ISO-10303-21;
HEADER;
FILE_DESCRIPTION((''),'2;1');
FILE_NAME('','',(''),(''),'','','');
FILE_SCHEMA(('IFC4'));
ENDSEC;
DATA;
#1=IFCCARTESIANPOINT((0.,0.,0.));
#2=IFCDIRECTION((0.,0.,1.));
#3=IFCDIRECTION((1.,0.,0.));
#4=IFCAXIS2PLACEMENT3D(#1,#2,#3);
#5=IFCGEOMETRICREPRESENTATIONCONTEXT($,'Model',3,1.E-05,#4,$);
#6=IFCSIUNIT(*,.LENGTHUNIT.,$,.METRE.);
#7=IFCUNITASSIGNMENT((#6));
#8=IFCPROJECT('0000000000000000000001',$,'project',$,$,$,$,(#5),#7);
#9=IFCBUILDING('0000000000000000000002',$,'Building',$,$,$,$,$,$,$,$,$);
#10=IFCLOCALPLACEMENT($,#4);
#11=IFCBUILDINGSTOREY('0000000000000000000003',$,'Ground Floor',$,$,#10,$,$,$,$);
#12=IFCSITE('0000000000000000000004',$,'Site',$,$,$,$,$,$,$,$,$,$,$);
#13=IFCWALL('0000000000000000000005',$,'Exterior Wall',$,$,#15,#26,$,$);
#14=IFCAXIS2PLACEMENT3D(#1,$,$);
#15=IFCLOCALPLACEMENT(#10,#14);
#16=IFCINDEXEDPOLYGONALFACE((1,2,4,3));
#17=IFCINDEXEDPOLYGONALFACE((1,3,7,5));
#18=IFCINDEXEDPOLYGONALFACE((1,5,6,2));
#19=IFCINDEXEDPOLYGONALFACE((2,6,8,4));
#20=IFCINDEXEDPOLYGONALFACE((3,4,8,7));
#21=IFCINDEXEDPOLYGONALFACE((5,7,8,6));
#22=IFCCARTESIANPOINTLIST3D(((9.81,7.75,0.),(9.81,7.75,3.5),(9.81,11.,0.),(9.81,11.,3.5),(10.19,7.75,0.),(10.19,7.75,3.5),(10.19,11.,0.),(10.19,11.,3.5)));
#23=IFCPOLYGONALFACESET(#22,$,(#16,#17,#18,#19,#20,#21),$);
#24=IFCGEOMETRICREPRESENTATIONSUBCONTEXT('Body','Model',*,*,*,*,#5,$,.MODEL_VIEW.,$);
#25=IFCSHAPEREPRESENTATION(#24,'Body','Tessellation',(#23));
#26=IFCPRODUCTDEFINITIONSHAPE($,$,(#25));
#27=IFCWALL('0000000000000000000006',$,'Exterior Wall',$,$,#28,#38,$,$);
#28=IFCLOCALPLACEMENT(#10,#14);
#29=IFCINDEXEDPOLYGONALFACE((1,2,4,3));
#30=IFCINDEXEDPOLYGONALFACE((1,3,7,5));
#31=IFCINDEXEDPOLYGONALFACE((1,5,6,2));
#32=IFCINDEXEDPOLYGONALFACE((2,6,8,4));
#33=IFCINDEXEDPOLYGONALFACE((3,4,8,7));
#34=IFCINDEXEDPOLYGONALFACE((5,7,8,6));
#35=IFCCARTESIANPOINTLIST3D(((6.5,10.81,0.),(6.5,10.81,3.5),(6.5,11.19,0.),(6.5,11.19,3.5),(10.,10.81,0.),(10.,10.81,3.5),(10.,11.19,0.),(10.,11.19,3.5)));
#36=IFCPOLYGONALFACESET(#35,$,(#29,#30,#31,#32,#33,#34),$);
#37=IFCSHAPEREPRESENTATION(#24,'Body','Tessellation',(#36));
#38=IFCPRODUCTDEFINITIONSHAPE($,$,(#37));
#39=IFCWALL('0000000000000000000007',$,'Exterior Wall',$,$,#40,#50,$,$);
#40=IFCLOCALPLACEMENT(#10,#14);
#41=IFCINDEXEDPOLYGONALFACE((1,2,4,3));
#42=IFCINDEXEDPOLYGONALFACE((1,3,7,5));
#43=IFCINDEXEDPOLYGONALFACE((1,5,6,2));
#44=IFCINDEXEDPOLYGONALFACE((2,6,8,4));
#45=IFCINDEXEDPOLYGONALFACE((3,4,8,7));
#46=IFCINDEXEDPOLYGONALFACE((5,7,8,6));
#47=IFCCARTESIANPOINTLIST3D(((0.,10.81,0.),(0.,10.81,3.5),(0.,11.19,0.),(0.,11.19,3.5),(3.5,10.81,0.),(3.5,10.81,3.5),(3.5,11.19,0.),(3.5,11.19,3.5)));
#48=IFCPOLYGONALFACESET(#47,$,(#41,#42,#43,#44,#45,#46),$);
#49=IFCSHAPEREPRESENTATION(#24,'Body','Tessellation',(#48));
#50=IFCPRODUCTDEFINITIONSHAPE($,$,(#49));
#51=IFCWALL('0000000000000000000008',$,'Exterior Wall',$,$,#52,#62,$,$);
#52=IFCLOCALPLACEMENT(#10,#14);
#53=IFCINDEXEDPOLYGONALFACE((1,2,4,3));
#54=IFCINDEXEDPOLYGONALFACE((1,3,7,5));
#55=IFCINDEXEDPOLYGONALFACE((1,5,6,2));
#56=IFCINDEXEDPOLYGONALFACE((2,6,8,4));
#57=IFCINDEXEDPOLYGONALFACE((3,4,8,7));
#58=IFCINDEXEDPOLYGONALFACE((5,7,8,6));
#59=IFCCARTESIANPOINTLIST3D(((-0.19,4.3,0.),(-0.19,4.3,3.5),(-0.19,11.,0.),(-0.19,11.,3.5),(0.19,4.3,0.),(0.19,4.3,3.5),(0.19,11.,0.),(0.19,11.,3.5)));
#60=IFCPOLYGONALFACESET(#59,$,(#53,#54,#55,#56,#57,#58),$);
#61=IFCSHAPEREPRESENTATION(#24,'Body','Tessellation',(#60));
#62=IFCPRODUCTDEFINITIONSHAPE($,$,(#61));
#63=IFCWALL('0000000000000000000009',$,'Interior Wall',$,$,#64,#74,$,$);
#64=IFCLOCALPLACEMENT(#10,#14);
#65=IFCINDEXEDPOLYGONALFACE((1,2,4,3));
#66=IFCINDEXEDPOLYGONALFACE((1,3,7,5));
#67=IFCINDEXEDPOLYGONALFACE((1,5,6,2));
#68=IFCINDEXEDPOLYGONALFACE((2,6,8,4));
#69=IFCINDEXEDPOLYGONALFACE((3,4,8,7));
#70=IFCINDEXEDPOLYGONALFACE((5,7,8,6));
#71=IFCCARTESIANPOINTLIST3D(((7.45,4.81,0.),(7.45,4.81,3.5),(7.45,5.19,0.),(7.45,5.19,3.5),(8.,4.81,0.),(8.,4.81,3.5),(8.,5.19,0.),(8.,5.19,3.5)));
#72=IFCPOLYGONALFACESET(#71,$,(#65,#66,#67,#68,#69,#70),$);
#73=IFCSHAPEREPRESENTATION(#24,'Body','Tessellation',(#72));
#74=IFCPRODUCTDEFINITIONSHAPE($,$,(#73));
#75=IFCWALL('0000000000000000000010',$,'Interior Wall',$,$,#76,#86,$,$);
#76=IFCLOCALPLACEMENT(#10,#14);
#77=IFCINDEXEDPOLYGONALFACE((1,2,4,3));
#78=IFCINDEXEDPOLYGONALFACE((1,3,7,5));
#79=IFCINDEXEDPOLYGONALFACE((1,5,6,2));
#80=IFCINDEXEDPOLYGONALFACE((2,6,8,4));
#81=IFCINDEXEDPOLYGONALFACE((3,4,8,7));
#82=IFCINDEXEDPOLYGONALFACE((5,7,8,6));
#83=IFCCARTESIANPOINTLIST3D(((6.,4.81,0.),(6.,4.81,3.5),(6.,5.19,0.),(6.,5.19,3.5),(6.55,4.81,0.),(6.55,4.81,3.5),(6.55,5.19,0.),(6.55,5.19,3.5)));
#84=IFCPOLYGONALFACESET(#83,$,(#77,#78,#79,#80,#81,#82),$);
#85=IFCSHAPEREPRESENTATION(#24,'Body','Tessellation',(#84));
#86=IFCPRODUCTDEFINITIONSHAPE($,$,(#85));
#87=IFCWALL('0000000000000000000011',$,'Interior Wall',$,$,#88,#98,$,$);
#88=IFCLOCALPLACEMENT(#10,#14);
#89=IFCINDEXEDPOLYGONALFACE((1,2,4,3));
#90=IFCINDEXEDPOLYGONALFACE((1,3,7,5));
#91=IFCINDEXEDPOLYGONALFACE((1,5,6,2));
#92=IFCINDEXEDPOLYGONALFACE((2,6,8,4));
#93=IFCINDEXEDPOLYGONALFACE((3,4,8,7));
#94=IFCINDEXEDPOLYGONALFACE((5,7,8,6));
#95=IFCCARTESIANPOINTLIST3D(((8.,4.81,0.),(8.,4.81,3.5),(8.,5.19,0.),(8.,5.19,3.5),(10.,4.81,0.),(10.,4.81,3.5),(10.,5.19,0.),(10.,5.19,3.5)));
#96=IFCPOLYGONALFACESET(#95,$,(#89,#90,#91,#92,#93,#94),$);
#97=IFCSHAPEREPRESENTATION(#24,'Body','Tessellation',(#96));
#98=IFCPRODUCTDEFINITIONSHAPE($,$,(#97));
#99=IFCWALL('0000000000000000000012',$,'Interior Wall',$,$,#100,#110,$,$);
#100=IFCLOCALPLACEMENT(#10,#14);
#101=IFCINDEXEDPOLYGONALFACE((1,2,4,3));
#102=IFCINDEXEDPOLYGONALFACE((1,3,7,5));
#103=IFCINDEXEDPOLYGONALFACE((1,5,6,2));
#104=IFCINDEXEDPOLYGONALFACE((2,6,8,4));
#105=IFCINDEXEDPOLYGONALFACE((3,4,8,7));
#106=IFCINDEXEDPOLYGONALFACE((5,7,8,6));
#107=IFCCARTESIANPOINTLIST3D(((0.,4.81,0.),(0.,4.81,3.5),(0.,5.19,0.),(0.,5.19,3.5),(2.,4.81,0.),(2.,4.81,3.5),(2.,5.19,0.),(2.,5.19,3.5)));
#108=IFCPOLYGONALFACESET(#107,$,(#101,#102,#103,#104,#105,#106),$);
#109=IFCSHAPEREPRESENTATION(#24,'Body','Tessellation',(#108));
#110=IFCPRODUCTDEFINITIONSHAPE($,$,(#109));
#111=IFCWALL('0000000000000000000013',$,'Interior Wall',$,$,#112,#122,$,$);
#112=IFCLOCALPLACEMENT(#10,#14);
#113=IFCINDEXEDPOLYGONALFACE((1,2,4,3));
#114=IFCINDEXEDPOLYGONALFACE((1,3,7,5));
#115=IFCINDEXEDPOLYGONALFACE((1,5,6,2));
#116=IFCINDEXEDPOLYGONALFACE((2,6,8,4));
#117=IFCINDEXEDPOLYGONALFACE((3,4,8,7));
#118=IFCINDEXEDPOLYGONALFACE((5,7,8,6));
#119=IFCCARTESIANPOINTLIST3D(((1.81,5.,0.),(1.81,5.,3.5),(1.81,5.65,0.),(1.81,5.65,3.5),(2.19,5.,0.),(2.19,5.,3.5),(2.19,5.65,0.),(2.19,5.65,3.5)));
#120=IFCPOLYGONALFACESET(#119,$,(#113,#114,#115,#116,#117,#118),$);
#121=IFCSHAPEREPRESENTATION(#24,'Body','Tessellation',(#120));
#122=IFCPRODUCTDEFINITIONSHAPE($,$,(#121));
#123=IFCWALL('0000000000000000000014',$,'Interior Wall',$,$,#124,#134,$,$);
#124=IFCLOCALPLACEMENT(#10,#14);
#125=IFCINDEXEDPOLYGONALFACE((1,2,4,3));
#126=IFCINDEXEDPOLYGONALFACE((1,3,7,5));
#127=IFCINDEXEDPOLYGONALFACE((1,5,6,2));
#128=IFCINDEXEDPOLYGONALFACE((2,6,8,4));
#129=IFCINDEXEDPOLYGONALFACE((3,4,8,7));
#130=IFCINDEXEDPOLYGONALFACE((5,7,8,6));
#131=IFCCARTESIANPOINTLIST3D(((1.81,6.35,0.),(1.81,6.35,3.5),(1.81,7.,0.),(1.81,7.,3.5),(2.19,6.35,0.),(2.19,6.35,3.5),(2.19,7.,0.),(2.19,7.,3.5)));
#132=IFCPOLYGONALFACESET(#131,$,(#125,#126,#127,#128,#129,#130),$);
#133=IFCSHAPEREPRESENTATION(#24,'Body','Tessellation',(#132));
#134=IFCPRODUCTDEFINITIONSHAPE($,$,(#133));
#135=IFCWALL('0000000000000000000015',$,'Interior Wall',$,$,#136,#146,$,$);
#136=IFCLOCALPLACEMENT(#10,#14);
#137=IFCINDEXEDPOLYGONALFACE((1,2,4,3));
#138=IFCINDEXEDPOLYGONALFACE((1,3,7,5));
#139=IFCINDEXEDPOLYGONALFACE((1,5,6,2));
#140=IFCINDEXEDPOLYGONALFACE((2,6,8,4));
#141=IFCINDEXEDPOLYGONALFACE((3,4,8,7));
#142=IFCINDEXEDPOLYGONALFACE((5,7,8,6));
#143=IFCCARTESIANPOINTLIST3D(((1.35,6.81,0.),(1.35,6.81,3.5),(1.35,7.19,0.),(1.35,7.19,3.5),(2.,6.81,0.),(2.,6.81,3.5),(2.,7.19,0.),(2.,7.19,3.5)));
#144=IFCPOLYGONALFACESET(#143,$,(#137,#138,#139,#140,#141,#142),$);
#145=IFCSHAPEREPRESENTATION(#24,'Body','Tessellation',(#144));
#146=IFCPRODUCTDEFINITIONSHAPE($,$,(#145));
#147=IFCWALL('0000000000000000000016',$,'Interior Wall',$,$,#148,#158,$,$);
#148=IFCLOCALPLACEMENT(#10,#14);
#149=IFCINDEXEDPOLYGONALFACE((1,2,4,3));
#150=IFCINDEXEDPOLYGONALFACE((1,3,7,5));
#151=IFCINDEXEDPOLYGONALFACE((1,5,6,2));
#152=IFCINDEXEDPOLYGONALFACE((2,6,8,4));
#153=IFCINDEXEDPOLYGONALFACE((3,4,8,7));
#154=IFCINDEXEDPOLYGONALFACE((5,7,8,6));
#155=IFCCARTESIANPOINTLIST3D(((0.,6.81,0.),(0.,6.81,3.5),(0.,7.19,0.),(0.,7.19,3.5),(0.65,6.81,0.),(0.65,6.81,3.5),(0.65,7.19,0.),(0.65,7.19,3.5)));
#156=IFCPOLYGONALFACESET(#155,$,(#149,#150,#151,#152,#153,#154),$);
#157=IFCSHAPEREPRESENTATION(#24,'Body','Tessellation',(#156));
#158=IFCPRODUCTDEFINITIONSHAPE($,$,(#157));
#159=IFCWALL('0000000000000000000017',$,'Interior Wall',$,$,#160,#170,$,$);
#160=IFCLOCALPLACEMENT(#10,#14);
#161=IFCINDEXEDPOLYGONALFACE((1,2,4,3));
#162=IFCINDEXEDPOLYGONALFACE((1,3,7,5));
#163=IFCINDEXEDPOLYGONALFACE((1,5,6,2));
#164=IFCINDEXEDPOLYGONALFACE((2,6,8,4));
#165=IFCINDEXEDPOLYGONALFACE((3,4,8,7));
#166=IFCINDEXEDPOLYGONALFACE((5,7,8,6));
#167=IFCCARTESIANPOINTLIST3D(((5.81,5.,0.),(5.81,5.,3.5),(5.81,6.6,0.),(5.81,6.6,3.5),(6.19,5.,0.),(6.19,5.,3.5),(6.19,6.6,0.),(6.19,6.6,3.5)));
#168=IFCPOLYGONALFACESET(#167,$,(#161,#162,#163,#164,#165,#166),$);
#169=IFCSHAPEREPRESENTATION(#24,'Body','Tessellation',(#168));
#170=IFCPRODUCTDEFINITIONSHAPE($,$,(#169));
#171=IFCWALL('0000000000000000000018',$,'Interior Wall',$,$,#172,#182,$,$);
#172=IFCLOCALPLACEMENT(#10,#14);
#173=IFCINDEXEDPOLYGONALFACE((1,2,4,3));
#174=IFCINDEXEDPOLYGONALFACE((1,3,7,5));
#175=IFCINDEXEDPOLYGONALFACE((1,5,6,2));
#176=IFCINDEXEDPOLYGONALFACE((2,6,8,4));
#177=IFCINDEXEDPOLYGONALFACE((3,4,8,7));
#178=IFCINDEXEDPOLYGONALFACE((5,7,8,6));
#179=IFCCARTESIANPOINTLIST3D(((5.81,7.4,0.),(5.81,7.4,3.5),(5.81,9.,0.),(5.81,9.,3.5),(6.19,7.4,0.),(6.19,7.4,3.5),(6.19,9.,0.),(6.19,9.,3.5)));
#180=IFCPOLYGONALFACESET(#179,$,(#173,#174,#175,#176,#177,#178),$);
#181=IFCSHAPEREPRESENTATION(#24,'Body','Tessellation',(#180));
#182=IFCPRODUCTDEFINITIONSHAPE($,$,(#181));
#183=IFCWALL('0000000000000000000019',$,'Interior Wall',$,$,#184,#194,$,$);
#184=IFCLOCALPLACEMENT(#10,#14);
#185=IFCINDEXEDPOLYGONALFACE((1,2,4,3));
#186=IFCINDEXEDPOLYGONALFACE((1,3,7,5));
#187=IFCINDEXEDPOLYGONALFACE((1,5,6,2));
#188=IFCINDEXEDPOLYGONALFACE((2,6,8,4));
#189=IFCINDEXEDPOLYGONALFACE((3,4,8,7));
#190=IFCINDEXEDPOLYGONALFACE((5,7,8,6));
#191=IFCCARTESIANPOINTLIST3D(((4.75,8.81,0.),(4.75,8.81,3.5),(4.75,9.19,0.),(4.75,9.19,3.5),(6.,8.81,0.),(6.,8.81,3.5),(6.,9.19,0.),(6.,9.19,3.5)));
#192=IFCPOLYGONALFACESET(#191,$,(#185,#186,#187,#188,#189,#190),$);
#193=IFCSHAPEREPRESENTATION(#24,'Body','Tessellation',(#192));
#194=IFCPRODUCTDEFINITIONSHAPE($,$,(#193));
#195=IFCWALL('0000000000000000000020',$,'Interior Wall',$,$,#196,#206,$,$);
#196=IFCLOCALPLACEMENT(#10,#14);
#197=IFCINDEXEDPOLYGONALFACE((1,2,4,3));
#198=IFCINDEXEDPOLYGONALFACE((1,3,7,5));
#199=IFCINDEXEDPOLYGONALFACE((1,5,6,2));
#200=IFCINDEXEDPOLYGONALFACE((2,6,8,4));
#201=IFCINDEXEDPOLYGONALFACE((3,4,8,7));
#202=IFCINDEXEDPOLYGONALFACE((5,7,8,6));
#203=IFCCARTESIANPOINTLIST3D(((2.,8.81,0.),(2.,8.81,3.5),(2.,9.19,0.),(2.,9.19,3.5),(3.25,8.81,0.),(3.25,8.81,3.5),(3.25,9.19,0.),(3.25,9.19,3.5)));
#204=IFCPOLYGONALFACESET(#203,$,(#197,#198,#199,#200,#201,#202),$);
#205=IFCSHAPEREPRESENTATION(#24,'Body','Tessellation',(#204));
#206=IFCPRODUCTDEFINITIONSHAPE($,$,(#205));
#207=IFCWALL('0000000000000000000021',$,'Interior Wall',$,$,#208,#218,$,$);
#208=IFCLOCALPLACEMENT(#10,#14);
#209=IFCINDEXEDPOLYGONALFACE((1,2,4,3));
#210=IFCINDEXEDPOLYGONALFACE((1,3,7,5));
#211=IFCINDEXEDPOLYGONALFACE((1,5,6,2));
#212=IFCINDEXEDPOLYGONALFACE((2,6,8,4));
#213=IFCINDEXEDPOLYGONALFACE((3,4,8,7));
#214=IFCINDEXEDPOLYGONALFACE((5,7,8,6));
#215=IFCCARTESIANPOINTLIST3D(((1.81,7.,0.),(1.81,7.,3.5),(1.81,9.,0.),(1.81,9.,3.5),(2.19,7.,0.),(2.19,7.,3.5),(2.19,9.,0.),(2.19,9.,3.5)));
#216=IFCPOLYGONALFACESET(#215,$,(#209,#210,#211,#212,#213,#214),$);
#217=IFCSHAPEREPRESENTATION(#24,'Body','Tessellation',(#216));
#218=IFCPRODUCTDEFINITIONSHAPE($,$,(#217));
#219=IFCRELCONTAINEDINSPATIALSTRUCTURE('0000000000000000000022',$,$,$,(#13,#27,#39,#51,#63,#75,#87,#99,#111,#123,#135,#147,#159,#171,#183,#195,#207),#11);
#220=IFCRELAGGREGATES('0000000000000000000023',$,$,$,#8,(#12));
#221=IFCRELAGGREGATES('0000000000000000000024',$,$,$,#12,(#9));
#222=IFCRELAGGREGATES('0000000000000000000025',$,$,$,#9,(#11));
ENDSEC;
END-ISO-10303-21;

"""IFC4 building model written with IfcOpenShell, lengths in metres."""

from ifc_helpers import new_model, si_unit, frame, origin_with_axes, place, context, subcontext, project, spatial, indexed_curve, outline, extrude, element, save


model = new_model("IFC4")

# Units and contexts
model_context = context("Model", 3, precision=1e-05, world=origin_with_axes())
body_context = subcontext(model_context, "Body", "Model", "MODEL_VIEW")
ifc_project = project(units=[si_unit("LENGTHUNIT", "METRE")], contexts=[model_context])

# Site, building, storey
site = spatial("IfcSite", under=ifc_project, Name="Site")
building = spatial("IfcBuilding", under=site, Name="Building")
storey_placement = place(None, origin_with_axes())
storey = spatial("IfcBuildingStorey", under=building, at=storey_placement, Name="Ground Floor")

# Walls
wall_1_placement = place(storey_placement, frame((10.0, 7.75, 0.0), z_axis=(0.0, 0.0, 1.0), x_axis=(0.0, 1.0, 0.0)))
element("IfcWall", 1, at=wall_1_placement, inside=storey, Name="Exterior Wall", context=body_context, shape_type="SweptSolid", body=[
    extrude(outline(indexed_curve([(0.0, 0.0), (0.0, 0.38), (3.25, 0.38), (3.25, 0.0), (0.0, 0.0)], self_intersect=False)), frame((0.0, -0.19, 0.0), z_axis=(0.0, 0.0, 1.0), x_axis=(1.0, 0.0, 0.0)), (0.0, 0.0, 1.0), 3.5),
])
for number, where, z_axis, x_axis, name in (
    (2, (10.0, 11.0, 0.0), (0.0, 0.0, 1.0), (-1.0, 0.0, 0.0), "Exterior Wall"),
    (3, (3.5, 11.0, 0.0), (0.0, 0.0, 1.0), (-1.0, 0.0, 0.0), "Exterior Wall"),
):
    element("IfcWall", number, at=place(storey_placement, frame(where, z_axis=z_axis, x_axis=x_axis)), inside=storey, Name=name, context=body_context, shape_type="SweptSolid", body=[
        extrude(outline(indexed_curve([(0.0, 0.0), (0.0, 0.38), (3.5, 0.38), (3.5, 0.0), (0.0, 0.0)], self_intersect=False)), frame((0.0, -0.19, 0.0), z_axis=(0.0, 0.0, 1.0), x_axis=(1.0, 0.0, 0.0)), (0.0, 0.0, 1.0), 3.5),
    ])
wall_2_placement = place(storey_placement, frame((0.0, 11.0, 0.0), z_axis=(0.0, 0.0, 1.0), x_axis=(0.0, -1.0, 0.0)))
element("IfcWall", 4, at=wall_2_placement, inside=storey, Name="Exterior Wall", context=body_context, shape_type="SweptSolid", body=[
    extrude(outline(indexed_curve([(0.0, 0.0), (0.0, 0.38), (6.7, 0.38), (6.7, 0.0), (0.0, 0.0)], self_intersect=False)), frame((0.0, -0.19, 0.0), z_axis=(0.0, 0.0, 1.0), x_axis=(1.0, 0.0, 0.0)), (0.0, 0.0, 1.0), 3.5),
])
for number, where, z_axis, x_axis, name in (
    (5, (8.0, 5.0, 0.0), (0.0, 0.0, 1.0), (-1.0, 0.0, 0.0), "Interior Wall"),
    (6, (6.55, 5.0, 0.0), (0.0, 0.0, 1.0), (-1.0, 0.0, 0.0), "Interior Wall"),
):
    element("IfcWall", number, at=place(storey_placement, frame(where, z_axis=z_axis, x_axis=x_axis)), inside=storey, Name=name, context=body_context, shape_type="SweptSolid", body=[
        extrude(outline(indexed_curve([(0.0, 0.0), (0.0, 0.38), (0.55, 0.38), (0.55, 0.0), (0.0, 0.0)], self_intersect=False)), frame((0.0, -0.19, 0.0), z_axis=(0.0, 0.0, 1.0), x_axis=(1.0, 0.0, 0.0)), (0.0, 0.0, 1.0), 3.5),
    ])
for number, where, z_axis, x_axis, name in (
    (7, (10.0, 5.0, 0.0), (0.0, 0.0, 1.0), (-1.0, 0.0, 0.0), "Interior Wall"),
    (8, (2.0, 5.0, 0.0), (0.0, 0.0, 1.0), (-1.0, 0.0, 0.0), "Interior Wall"),
):
    element("IfcWall", number, at=place(storey_placement, frame(where, z_axis=z_axis, x_axis=x_axis)), inside=storey, Name=name, context=body_context, shape_type="SweptSolid", body=[
        extrude(outline(indexed_curve([(0.0, 0.0), (0.0, 0.38), (2.0, 0.38), (2.0, 0.0), (0.0, 0.0)], self_intersect=False)), frame((0.0, -0.19, 0.0), z_axis=(0.0, 0.0, 1.0), x_axis=(1.0, 0.0, 0.0)), (0.0, 0.0, 1.0), 3.5),
    ])
for number, where, z_axis, x_axis, name in (
    (9, (2.0, 5.0, 0.0), (0.0, 0.0, 1.0), (0.0, 1.0, 0.0), "Interior Wall"),
    (10, (2.0, 6.35, 0.0), (0.0, 0.0, 1.0), (0.0, 1.0, 0.0), "Interior Wall"),
):
    element("IfcWall", number, at=place(storey_placement, frame(where, z_axis=z_axis, x_axis=x_axis)), inside=storey, Name=name, context=body_context, shape_type="SweptSolid", body=[
        extrude(outline(indexed_curve([(0.0, 0.0), (0.0, 0.38), (0.65, 0.38), (0.65, 0.0), (0.0, 0.0)], self_intersect=False)), frame((0.0, -0.19, 0.0), z_axis=(0.0, 0.0, 1.0), x_axis=(1.0, 0.0, 0.0)), (0.0, 0.0, 1.0), 3.5),
    ])
for number, where, z_axis, x_axis, name in (
    (11, (2.0, 7.0, 0.0), (0.0, 0.0, 1.0), (-1.0, 0.0, 0.0), "Interior Wall"),
    (12, (0.65, 7.0, 0.0), (0.0, 0.0, 1.0), (-1.0, 0.0, 0.0), "Interior Wall"),
):
    element("IfcWall", number, at=place(storey_placement, frame(where, z_axis=z_axis, x_axis=x_axis)), inside=storey, Name=name, context=body_context, shape_type="SweptSolid", body=[
        extrude(outline(indexed_curve([(0.0, 0.0), (0.0, 0.38), (0.65, 0.38), (0.65, 0.0), (0.0, 0.0)], self_intersect=False)), frame((0.0, -0.19, 0.0), z_axis=(0.0, 0.0, 1.0), x_axis=(1.0, 0.0, 0.0)), (0.0, 0.0, 1.0), 3.5),
    ])
for number, where, z_axis, x_axis, name in (
    (13, (6.0, 5.0, 0.0), (0.0, 0.0, 1.0), (0.0, 1.0, 0.0), "Interior Wall"),
    (14, (6.0, 7.4, 0.0), (0.0, 0.0, 1.0), (0.0, 1.0, 0.0), "Interior Wall"),
):
    element("IfcWall", number, at=place(storey_placement, frame(where, z_axis=z_axis, x_axis=x_axis)), inside=storey, Name=name, context=body_context, shape_type="SweptSolid", body=[
        extrude(outline(indexed_curve([(0.0, 0.0), (0.0, 0.38), (1.6, 0.38), (1.6, 0.0), (0.0, 0.0)], self_intersect=False)), frame((0.0, -0.19, 0.0), z_axis=(0.0, 0.0, 1.0), x_axis=(1.0, 0.0, 0.0)), (0.0, 0.0, 1.0), 3.5),
    ])
for number, where, z_axis, x_axis, name in (
    (15, (6.0, 9.0, 0.0), (0.0, 0.0, 1.0), (-1.0, 0.0, 0.0), "Interior Wall"),
    (16, (3.25, 9.0, 0.0), (0.0, 0.0, 1.0), (-1.0, 0.0, 0.0), "Interior Wall"),
):
    element("IfcWall", number, at=place(storey_placement, frame(where, z_axis=z_axis, x_axis=x_axis)), inside=storey, Name=name, context=body_context, shape_type="SweptSolid", body=[
        extrude(outline(indexed_curve([(0.0, 0.0), (0.0, 0.38), (1.25, 0.38), (1.25, 0.0), (0.0, 0.0)], self_intersect=False)), frame((0.0, -0.19, 0.0), z_axis=(0.0, 0.0, 1.0), x_axis=(1.0, 0.0, 0.0)), (0.0, 0.0, 1.0), 3.5),
    ])
wall_3_placement = place(storey_placement, frame((2.0, 9.0, 0.0), z_axis=(0.0, 0.0, 1.0), x_axis=(0.0, -1.0, 0.0)))
element("IfcWall", 17, at=wall_3_placement, inside=storey, Name="Interior Wall", context=body_context, shape_type="SweptSolid", body=[
    extrude(outline(indexed_curve([(0.0, 0.0), (0.0, 0.38), (2.0, 0.38), (2.0, 0.0), (0.0, 0.0)], self_intersect=False)), frame((0.0, -0.19, 0.0), z_axis=(0.0, 0.0, 1.0), x_axis=(1.0, 0.0, 0.0)), (0.0, 0.0, 1.0), 3.5),
])

save(model, "model.ifc")
